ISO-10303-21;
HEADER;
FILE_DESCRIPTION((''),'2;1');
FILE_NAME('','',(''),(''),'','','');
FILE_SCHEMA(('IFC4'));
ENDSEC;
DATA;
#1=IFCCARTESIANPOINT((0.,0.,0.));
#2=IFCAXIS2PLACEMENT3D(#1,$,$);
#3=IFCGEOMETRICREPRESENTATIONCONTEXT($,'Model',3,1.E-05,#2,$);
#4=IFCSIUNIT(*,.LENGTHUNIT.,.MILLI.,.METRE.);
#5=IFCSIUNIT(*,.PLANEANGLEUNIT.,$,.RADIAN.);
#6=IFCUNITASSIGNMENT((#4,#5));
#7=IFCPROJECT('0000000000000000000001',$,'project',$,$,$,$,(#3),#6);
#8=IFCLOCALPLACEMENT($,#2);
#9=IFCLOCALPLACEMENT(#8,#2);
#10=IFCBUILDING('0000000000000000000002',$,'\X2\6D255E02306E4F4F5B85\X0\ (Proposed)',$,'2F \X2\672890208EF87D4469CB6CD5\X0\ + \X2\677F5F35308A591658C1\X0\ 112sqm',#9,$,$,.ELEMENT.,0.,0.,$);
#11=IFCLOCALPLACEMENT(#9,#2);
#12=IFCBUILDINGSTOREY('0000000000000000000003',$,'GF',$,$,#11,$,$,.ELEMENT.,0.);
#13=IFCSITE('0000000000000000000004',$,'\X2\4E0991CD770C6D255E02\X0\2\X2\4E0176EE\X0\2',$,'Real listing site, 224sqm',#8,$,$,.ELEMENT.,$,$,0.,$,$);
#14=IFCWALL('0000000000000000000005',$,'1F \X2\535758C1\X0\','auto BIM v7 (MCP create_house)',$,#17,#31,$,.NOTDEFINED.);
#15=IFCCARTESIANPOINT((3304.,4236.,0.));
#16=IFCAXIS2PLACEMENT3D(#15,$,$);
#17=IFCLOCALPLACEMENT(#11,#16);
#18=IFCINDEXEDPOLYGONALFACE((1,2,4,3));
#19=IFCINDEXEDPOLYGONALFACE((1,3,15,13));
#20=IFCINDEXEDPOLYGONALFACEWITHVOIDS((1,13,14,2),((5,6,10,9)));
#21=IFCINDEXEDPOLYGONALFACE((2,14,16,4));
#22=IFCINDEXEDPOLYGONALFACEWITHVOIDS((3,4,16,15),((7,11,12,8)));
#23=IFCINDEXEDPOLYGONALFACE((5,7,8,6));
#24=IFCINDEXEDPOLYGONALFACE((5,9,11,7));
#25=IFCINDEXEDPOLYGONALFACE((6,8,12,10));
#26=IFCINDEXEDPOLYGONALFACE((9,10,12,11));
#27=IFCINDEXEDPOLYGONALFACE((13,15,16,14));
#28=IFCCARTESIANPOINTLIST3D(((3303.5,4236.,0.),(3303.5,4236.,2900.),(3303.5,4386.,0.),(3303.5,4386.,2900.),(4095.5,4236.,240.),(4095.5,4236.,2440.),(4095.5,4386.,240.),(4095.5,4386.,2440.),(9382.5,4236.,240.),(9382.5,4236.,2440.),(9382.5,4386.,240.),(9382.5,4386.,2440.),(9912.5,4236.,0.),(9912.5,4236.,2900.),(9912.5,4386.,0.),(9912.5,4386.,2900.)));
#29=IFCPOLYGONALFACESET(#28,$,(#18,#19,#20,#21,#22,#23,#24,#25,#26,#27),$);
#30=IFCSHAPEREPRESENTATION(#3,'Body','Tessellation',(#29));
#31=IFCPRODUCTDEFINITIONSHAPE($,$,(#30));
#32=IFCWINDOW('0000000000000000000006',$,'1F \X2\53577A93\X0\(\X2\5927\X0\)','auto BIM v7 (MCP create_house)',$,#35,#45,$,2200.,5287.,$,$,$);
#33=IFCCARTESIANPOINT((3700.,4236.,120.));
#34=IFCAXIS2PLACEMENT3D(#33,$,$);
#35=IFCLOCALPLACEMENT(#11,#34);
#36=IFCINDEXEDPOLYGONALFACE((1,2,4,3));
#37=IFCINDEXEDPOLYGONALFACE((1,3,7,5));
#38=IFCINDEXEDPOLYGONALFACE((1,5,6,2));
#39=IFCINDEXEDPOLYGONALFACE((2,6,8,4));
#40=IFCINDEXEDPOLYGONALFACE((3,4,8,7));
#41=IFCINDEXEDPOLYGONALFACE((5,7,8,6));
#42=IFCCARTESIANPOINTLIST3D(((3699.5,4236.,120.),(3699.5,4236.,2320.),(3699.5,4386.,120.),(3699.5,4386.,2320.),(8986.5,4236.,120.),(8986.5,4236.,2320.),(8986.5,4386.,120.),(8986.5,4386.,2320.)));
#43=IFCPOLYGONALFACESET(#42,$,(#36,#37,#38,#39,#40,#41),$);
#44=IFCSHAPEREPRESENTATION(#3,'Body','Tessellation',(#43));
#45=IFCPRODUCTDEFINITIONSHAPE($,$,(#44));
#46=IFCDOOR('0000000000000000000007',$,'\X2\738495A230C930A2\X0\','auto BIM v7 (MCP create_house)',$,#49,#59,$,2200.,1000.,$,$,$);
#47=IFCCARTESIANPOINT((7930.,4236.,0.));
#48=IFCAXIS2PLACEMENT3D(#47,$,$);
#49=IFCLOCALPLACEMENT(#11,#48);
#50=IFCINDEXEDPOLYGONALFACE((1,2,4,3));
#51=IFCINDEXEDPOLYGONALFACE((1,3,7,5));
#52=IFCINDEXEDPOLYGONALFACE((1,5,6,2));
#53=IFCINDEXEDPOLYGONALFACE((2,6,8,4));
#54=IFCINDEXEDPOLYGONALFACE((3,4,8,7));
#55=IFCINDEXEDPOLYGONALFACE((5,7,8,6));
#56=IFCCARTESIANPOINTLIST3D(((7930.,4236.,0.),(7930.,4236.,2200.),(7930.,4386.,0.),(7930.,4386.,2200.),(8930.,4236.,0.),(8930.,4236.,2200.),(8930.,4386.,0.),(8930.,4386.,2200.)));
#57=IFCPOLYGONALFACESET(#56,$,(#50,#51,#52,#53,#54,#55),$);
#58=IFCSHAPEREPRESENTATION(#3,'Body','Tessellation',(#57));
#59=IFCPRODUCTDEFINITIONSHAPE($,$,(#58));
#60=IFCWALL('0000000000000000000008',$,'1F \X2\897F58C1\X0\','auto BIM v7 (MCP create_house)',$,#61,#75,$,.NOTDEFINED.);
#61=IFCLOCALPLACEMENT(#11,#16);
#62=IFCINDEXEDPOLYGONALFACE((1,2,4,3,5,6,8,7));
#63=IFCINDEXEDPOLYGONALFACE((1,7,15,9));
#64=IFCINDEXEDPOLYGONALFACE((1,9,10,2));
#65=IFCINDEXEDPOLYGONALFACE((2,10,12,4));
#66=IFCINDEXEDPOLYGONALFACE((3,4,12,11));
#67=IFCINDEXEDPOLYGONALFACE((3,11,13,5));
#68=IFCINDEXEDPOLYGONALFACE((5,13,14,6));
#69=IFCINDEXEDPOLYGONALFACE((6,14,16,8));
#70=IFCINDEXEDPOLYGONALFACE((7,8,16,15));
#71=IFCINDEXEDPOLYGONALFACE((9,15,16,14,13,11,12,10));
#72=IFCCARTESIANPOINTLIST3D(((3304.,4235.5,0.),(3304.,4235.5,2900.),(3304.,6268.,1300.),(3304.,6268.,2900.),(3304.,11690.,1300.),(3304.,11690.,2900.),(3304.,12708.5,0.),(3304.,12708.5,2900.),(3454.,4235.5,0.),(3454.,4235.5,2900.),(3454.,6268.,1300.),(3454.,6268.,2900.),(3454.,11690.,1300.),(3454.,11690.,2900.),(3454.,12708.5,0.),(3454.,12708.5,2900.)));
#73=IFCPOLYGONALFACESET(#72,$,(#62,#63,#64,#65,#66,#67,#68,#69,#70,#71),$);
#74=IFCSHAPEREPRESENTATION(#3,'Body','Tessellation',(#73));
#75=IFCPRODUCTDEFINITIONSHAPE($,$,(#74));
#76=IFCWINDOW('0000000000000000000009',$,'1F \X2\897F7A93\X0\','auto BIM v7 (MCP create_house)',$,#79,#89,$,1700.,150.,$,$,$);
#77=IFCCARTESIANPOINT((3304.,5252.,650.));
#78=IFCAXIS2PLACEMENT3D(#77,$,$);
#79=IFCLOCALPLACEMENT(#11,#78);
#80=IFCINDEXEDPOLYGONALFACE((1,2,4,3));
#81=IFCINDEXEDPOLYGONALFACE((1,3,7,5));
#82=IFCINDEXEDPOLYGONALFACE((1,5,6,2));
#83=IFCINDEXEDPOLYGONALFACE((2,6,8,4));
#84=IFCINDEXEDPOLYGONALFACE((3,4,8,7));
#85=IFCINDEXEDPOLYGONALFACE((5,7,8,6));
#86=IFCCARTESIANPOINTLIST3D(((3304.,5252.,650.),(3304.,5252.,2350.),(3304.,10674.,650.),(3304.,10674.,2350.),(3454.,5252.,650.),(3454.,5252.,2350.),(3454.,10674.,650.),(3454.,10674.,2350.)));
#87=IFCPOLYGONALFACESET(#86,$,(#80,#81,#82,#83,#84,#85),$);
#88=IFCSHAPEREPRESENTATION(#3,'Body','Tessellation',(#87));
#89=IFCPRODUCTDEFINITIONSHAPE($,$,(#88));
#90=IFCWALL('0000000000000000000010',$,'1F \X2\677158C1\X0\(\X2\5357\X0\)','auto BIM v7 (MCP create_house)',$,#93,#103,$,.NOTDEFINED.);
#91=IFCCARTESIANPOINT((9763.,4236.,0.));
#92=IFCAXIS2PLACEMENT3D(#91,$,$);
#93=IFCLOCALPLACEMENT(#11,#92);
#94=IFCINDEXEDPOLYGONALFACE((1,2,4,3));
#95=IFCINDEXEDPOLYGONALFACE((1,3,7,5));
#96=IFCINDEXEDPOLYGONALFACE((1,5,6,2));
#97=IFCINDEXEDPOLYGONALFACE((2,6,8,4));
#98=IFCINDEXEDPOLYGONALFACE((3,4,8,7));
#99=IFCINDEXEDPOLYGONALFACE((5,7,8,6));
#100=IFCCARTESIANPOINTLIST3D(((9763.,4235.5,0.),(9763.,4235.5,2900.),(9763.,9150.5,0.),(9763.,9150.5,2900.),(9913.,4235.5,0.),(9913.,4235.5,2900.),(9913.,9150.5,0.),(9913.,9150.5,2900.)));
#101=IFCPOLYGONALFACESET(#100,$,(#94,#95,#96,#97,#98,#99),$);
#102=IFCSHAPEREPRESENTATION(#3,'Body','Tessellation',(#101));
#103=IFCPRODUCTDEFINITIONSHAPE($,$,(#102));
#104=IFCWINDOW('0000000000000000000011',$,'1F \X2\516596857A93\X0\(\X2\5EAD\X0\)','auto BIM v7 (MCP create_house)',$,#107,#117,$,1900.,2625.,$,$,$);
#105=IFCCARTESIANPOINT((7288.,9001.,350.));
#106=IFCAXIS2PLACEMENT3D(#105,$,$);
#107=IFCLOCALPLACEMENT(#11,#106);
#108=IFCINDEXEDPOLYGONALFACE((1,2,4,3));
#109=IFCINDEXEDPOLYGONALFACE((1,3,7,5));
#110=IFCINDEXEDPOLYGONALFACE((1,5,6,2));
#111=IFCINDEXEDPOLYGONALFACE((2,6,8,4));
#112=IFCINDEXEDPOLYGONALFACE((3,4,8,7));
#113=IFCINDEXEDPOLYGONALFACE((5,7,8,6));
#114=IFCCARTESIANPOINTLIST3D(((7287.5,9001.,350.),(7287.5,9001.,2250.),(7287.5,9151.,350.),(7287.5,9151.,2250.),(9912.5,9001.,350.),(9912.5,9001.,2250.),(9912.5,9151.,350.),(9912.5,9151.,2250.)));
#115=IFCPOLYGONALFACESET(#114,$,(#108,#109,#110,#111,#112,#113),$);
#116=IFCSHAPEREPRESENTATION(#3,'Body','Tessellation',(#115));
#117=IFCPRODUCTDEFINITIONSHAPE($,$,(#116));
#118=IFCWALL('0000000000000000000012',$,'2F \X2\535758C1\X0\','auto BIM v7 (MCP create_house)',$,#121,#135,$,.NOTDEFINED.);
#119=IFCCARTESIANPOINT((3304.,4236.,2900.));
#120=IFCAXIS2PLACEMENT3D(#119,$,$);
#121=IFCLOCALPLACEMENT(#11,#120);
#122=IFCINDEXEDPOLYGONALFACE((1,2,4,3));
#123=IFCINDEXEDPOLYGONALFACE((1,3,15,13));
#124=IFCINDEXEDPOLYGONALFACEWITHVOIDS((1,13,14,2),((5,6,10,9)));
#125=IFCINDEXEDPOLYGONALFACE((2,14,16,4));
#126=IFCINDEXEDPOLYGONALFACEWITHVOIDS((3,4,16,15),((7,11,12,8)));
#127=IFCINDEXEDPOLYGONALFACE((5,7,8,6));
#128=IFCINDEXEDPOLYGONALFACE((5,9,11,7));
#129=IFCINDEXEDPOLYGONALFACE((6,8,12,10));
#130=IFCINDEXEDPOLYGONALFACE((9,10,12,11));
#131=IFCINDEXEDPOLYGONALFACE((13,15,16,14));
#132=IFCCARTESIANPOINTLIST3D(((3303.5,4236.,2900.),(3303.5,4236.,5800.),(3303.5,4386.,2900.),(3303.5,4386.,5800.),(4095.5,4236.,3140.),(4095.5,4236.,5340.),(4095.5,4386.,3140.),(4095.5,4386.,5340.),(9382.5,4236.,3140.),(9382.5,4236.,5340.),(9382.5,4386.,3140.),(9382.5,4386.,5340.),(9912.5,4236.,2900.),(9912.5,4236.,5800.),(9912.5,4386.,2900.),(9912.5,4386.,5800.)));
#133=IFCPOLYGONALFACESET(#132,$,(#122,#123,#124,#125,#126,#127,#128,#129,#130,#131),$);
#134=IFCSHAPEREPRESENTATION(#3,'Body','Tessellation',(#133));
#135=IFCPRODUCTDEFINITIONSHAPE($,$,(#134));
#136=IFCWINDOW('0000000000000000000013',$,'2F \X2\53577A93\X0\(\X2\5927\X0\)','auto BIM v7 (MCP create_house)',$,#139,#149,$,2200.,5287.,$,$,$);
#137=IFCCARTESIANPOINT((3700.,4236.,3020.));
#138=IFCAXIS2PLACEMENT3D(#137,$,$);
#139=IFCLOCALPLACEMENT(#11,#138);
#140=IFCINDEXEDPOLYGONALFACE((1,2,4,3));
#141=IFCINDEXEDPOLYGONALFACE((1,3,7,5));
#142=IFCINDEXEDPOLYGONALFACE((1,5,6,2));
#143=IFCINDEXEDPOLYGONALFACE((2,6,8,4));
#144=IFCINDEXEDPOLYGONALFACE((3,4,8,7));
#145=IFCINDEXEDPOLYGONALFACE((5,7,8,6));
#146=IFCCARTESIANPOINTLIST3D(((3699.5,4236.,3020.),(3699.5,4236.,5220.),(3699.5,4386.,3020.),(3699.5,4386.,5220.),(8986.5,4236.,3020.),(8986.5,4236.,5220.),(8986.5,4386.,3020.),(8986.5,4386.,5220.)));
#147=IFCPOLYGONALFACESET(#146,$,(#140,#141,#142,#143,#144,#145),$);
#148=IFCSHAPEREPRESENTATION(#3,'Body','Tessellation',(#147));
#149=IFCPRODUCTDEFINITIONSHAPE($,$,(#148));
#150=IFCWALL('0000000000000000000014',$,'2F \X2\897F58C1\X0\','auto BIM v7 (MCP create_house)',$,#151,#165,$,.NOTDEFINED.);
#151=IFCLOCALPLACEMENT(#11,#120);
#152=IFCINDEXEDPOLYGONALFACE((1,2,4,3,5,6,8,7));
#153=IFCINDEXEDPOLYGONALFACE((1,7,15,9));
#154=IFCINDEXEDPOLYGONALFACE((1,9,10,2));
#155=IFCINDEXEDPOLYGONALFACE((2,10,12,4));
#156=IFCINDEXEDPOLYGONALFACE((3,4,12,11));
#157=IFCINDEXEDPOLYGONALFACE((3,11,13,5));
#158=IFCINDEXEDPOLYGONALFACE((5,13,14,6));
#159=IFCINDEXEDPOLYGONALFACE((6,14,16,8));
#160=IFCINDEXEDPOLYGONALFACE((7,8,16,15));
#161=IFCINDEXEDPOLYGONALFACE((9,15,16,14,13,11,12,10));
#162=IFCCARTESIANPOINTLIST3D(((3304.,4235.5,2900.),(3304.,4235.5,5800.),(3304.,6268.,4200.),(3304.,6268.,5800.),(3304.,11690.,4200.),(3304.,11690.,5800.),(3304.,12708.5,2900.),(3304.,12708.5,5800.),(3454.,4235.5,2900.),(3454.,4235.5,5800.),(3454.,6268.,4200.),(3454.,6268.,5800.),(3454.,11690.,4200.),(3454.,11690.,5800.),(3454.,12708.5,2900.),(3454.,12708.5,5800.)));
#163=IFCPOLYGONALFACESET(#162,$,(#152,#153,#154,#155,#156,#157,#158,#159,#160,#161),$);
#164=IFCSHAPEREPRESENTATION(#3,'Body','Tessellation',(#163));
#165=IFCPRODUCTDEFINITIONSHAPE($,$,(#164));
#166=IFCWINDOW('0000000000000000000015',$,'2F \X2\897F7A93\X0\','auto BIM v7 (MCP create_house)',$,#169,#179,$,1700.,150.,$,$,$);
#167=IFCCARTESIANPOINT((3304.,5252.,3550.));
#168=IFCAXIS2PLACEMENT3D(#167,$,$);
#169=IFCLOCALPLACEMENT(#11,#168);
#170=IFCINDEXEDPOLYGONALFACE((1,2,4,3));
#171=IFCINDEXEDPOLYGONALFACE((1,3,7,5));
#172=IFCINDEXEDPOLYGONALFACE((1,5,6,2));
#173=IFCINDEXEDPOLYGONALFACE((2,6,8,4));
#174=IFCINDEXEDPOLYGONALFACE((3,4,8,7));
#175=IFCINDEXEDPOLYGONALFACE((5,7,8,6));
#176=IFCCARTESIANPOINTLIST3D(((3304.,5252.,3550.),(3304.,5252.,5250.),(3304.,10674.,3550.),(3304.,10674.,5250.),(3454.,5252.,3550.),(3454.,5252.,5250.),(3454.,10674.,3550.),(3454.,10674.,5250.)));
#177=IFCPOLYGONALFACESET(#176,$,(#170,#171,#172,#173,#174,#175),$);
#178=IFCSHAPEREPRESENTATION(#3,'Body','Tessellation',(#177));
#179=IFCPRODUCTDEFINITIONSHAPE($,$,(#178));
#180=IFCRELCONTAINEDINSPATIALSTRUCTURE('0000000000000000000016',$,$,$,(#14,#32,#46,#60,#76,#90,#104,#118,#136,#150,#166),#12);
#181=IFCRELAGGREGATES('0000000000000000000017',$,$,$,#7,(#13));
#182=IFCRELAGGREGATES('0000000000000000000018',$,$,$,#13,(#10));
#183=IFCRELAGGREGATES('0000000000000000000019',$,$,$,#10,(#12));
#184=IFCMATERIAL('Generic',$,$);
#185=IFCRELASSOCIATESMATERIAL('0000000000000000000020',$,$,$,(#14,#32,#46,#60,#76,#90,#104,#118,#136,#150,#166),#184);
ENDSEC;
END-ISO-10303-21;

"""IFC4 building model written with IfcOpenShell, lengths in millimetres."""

from ifc_helpers import new_model, si_unit, frame, frame_2d, origin, place, context, project, spatial, rectangle, extrude, material, element, fill, save


model = new_model("IFC4")

# Units and contexts
model_context = context("Model", 3, precision=1e-05, world=origin())
ifc_project = project(units=[si_unit("LENGTHUNIT", "METRE", prefix="MILLI"), si_unit("PLANEANGLEUNIT", "RADIAN")], contexts=[model_context])

# Site, building, storey
site_placement = place(None, origin())
site = spatial("IfcSite", under=ifc_project, at=site_placement, Name="三重県津市2丁目2", ObjectType="Real listing site, 224sqm", CompositionType="ELEMENT", RefElevation=0.0)
building_placement = place(site_placement, origin())
building = spatial("IfcBuilding", under=site, at=building_placement, Name="津市の住宅 (Proposed)", ObjectType="2F 木造軸組構法 + 板張り外壁 112sqm", CompositionType="ELEMENT", ElevationOfRefHeight=0.0, ElevationOfTerrain=0.0)
storey_placement = place(building_placement, origin())
storey = spatial("IfcBuildingStorey", under=building, at=storey_placement, Name="GF", CompositionType="ELEMENT", Elevation=0.0)

# Shared definitions
ifc_material = material(Name="Generic")

# Wall, openings, window, door
wall_1_placement = place(storey_placement, frame((3304.0, 4236.0, 0.0)))
wall_1 = element("IfcWall", 1, at=wall_1_placement, inside=storey, material=ifc_material, Name="1F 南壁", Description="auto BIM v7 (MCP create_house)", PredefinedType="NOTDEFINED", context=model_context, shape_type="SweptSolid", body=[
    extrude(rectangle(XDim=6609.0, YDim=150.0, at=frame_2d((3304.0, 75.0))), frame((3304.0, 4236.0, 0.0)), (0.0, 0.0, 1.0), 2900.0),
])
opening_1_placement = place(storey_placement, frame((3700.0, 4236.0, 120.0)))
opening_1 = element("IfcOpeningElement", 2, at=opening_1_placement, cuts=wall_1, PredefinedType="NOTDEFINED", context=model_context, shape_type="SweptSolid", body=[
    extrude(rectangle(XDim=5287.0, YDim=150.0, at=frame_2d((2643.0, 75.0))), frame((3700.0, 4236.0, 120.0)), (0.0, 0.0, 1.0), 2200.0),
])
opening_2_placement = place(storey_placement, frame((7930.0, 4236.0, 0.0)))
opening_2 = element("IfcOpeningElement", 3, at=opening_2_placement, cuts=wall_1, PredefinedType="NOTDEFINED", context=model_context, shape_type="SweptSolid", body=[
    extrude(rectangle(XDim=1000.0, YDim=150.0, at=frame_2d((500.0, 75.0))), frame((7930.0, 4236.0, 0.0)), (0.0, 0.0, 1.0), 2200.0),
])
window_1_placement = place(storey_placement, frame((3700.0, 4236.0, 120.0)))
window_1 = element("IfcWindow", 4, at=window_1_placement, inside=storey, material=ifc_material, Name="1F 南窓(大)", Description="auto BIM v7 (MCP create_house)", OverallHeight=2200.0, OverallWidth=5287.0, context=model_context, shape_type="SweptSolid", body=[
    extrude(rectangle(XDim=5287.0, YDim=150.0, at=frame_2d((2643.0, 75.0))), frame((3700.0, 4236.0, 120.0)), (0.0, 0.0, 1.0), 2200.0),
])
fill(opening_1, window_1)
door_placement = place(storey_placement, frame((7930.0, 4236.0, 0.0)))
door = element("IfcDoor", 5, at=door_placement, inside=storey, material=ifc_material, Name="玄関ドア", Description="auto BIM v7 (MCP create_house)", OverallHeight=2200.0, OverallWidth=1000.0, context=model_context, shape_type="SweptSolid", body=[
    extrude(rectangle(XDim=1000.0, YDim=150.0, at=frame_2d((500.0, 75.0))), frame((7930.0, 4236.0, 0.0)), (0.0, 0.0, 1.0), 2200.0),
])
fill(opening_2, door)

# Walls, openings, windows
wall_2_placement = place(storey_placement, frame((3304.0, 4236.0, 0.0)))
wall_2 = element("IfcWall", 6, at=wall_2_placement, inside=storey, material=ifc_material, Name="1F 西壁", Description="auto BIM v7 (MCP create_house)", PredefinedType="NOTDEFINED", context=model_context, shape_type="SweptSolid", body=[
    extrude(rectangle(XDim=150.0, YDim=8473.0, at=frame_2d((75.0, 4236.0))), frame((3304.0, 4236.0, 0.0)), (0.0, 0.0, 1.0), 2900.0),
])
opening_3_placement = place(storey_placement, frame((3304.0, 5252.0, 650.0)))
opening_3 = element("IfcOpeningElement", 7, at=opening_3_placement, cuts=wall_2, PredefinedType="NOTDEFINED", context=model_context, shape_type="SweptSolid", body=[
    extrude(rectangle(XDim=150.0, YDim=5422.0, at=frame_2d((75.0, 2711.0))), frame((3304.0, 5252.0, 650.0)), (0.0, 0.0, 1.0), 1700.0),
])
window_2_placement = place(storey_placement, frame((3304.0, 5252.0, 650.0)))
window_2 = element("IfcWindow", 8, at=window_2_placement, inside=storey, material=ifc_material, Name="1F 西窓", Description="auto BIM v7 (MCP create_house)", OverallHeight=1700.0, OverallWidth=150.0, context=model_context, shape_type="SweptSolid", body=[
    extrude(rectangle(XDim=150.0, YDim=5422.0, at=frame_2d((75.0, 2711.0))), frame((3304.0, 5252.0, 650.0)), (0.0, 0.0, 1.0), 1700.0),
])
fill(opening_3, window_2)
wall_3_placement = place(storey_placement, frame((9763.0, 4236.0, 0.0)))
wall_3 = element("IfcWall", 9, at=wall_3_placement, inside=storey, material=ifc_material, Name="1F 東壁(南)", Description="auto BIM v7 (MCP create_house)", PredefinedType="NOTDEFINED", context=model_context, shape_type="SweptSolid", body=[
    extrude(rectangle(XDim=150.0, YDim=4915.0, at=frame_2d((75.0, 2457.0))), frame((9763.0, 4236.0, 0.0)), (0.0, 0.0, 1.0), 2900.0),
])
opening_4_placement = place(storey_placement, frame((7288.0, 9001.0, 350.0)))
opening_4 = element("IfcOpeningElement", 10, at=opening_4_placement, cuts=wall_3, PredefinedType="NOTDEFINED", context=model_context, shape_type="SweptSolid", body=[
    extrude(rectangle(XDim=2625.0, YDim=150.0, at=frame_2d((1312.0, 75.0))), frame((7288.0, 9001.0, 350.0)), (0.0, 0.0, 1.0), 1900.0),
])
window_3_placement = place(storey_placement, frame((7288.0, 9001.0, 350.0)))
window_3 = element("IfcWindow", 11, at=window_3_placement, inside=storey, material=ifc_material, Name="1F 入隅窓(庭)", Description="auto BIM v7 (MCP create_house)", OverallHeight=1900.0, OverallWidth=2625.0, context=model_context, shape_type="SweptSolid", body=[
    extrude(rectangle(XDim=2625.0, YDim=150.0, at=frame_2d((1312.0, 75.0))), frame((7288.0, 9001.0, 350.0)), (0.0, 0.0, 1.0), 1900.0),
])
fill(opening_4, window_3)

# Walls, openings, windows
wall_4_placement = place(storey_placement, frame((3304.0, 4236.0, 2900.0)))
wall_4 = element("IfcWall", 12, at=wall_4_placement, inside=storey, material=ifc_material, Name="2F 南壁", Description="auto BIM v7 (MCP create_house)", PredefinedType="NOTDEFINED", context=model_context, shape_type="SweptSolid", body=[
    extrude(rectangle(XDim=6609.0, YDim=150.0, at=frame_2d((3304.0, 75.0))), frame((3304.0, 4236.0, 2900.0)), (0.0, 0.0, 1.0), 2900.0),
])
opening_5_placement = place(storey_placement, frame((3700.0, 4236.0, 3020.0)))
opening_5 = element("IfcOpeningElement", 13, at=opening_5_placement, cuts=wall_4, PredefinedType="NOTDEFINED", context=model_context, shape_type="SweptSolid", body=[
    extrude(rectangle(XDim=5287.0, YDim=150.0, at=frame_2d((2643.0, 75.0))), frame((3700.0, 4236.0, 3020.0)), (0.0, 0.0, 1.0), 2200.0),
])
window_4_placement = place(storey_placement, frame((3700.0, 4236.0, 3020.0)))
window_4 = element("IfcWindow", 14, at=window_4_placement, inside=storey, material=ifc_material, Name="2F 南窓(大)", Description="auto BIM v7 (MCP create_house)", OverallHeight=2200.0, OverallWidth=5287.0, context=model_context, shape_type="SweptSolid", body=[
    extrude(rectangle(XDim=5287.0, YDim=150.0, at=frame_2d((2643.0, 75.0))), frame((3700.0, 4236.0, 3020.0)), (0.0, 0.0, 1.0), 2200.0),
])
fill(opening_5, window_4)
wall_5_placement = place(storey_placement, frame((3304.0, 4236.0, 2900.0)))
wall_5 = element("IfcWall", 15, at=wall_5_placement, inside=storey, material=ifc_material, Name="2F 西壁", Description="auto BIM v7 (MCP create_house)", PredefinedType="NOTDEFINED", context=model_context, shape_type="SweptSolid", body=[
    extrude(rectangle(XDim=150.0, YDim=8473.0, at=frame_2d((75.0, 4236.0))), frame((3304.0, 4236.0, 2900.0)), (0.0, 0.0, 1.0), 2900.0),
])
opening_6_placement = place(storey_placement, frame((3304.0, 5252.0, 3550.0)))
opening_6 = element("IfcOpeningElement", 16, at=opening_6_placement, cuts=wall_5, PredefinedType="NOTDEFINED", context=model_context, shape_type="SweptSolid", body=[
    extrude(rectangle(XDim=150.0, YDim=5422.0, at=frame_2d((75.0, 2711.0))), frame((3304.0, 5252.0, 3550.0)), (0.0, 0.0, 1.0), 1700.0),
])
window_5_placement = place(storey_placement, frame((3304.0, 5252.0, 3550.0)))
window_5 = element("IfcWindow", 17, at=window_5_placement, inside=storey, material=ifc_material, Name="2F 西窓", Description="auto BIM v7 (MCP create_house)", OverallHeight=1700.0, OverallWidth=150.0, context=model_context, shape_type="SweptSolid", body=[
    extrude(rectangle(XDim=150.0, YDim=5422.0, at=frame_2d((75.0, 2711.0))), frame((3304.0, 5252.0, 3550.0)), (0.0, 0.0, 1.0), 1700.0),
])
fill(opening_6, window_5)

save(model, "model.ifc")
